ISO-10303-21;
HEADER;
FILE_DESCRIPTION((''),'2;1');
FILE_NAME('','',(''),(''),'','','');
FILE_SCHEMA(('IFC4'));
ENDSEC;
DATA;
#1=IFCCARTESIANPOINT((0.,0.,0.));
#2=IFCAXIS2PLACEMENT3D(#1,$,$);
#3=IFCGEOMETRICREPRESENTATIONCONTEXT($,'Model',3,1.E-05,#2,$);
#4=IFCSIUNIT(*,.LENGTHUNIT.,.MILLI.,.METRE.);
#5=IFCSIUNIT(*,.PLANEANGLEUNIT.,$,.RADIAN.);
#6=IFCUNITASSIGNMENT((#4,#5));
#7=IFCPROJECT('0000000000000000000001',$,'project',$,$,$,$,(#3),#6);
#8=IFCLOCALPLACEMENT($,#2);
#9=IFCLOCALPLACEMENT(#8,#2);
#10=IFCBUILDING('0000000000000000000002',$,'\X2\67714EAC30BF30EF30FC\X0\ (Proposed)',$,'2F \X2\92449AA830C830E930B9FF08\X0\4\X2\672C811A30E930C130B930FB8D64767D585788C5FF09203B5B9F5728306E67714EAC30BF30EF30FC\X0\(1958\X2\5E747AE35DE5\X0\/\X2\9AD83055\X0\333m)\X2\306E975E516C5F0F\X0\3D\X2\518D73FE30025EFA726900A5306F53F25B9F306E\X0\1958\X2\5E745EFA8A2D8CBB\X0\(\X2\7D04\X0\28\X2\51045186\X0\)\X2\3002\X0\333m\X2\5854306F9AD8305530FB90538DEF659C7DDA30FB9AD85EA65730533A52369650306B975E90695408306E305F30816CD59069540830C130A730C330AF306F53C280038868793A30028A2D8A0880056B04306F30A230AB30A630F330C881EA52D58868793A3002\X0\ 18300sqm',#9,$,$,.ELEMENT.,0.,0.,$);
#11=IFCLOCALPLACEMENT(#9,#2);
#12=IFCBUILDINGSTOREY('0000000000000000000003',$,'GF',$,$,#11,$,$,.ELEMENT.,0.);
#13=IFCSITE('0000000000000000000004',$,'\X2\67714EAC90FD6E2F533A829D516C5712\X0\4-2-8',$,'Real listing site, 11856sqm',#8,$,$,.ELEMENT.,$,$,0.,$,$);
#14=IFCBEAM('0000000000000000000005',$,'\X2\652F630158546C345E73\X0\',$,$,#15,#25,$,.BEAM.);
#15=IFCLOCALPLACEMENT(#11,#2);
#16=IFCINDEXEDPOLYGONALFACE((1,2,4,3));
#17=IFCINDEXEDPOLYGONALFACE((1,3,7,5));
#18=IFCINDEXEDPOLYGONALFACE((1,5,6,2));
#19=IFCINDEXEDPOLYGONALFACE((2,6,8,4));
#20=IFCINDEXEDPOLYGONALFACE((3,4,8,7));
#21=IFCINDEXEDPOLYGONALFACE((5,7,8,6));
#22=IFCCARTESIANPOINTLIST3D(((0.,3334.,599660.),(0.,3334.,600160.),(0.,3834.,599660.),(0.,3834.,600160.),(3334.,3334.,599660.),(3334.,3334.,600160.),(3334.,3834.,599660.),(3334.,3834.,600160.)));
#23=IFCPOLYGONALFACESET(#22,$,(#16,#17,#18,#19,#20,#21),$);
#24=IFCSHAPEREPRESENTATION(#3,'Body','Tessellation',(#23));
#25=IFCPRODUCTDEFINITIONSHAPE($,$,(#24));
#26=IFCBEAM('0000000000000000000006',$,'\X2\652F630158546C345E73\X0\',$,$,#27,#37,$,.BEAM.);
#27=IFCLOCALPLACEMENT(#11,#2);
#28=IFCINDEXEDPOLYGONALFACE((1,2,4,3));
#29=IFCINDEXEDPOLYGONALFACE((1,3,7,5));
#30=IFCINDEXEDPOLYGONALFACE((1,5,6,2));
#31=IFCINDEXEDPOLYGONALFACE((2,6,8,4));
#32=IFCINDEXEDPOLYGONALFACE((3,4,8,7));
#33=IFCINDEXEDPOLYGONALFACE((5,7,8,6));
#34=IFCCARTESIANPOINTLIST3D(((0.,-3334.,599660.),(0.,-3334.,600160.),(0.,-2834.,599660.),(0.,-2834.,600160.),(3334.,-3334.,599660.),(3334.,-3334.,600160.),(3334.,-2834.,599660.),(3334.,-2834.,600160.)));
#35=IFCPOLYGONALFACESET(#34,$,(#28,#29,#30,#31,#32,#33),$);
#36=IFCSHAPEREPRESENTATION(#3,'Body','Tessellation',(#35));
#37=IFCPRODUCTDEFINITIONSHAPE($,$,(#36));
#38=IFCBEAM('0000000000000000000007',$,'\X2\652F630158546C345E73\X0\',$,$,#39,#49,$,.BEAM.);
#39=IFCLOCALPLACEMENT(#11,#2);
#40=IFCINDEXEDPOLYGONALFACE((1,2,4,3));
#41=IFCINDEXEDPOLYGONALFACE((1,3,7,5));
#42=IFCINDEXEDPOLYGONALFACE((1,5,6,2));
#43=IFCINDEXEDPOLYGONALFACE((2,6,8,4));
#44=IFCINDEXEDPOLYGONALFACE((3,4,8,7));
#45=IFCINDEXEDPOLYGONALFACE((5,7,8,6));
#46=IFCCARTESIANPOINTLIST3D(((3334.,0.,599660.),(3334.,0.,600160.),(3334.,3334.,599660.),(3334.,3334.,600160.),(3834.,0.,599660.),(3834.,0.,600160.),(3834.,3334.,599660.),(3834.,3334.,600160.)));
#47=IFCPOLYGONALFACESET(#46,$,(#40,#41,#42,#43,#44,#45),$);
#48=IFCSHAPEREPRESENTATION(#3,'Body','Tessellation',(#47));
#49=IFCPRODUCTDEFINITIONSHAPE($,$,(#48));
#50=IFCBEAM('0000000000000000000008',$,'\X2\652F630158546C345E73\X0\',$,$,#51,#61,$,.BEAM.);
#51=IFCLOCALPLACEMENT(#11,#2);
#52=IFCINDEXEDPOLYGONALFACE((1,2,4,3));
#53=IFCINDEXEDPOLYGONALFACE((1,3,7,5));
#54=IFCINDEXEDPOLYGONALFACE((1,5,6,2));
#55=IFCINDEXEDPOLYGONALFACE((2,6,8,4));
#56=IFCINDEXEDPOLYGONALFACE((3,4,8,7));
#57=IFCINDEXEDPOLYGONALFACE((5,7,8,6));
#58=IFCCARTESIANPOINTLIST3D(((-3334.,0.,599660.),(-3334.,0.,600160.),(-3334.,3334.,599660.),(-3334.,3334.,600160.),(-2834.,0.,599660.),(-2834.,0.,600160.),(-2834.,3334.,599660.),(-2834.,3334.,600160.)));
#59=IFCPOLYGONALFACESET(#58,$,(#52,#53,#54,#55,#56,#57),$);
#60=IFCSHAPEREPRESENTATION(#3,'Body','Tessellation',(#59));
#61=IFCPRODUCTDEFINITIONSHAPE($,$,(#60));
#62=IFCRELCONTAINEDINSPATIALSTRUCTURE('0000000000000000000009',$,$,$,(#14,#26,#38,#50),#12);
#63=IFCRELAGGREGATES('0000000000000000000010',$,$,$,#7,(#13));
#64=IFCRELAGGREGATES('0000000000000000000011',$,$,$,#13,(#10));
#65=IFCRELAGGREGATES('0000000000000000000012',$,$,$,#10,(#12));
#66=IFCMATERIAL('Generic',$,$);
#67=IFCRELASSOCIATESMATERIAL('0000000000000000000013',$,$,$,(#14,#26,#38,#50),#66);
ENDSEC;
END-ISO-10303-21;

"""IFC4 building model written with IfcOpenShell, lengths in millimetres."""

from ifc_helpers import new_model, si_unit, frame, frame_2d, origin, place, context, project, spatial, rectangle, extrude, material, element, save


model = new_model("IFC4")

# Units and contexts
model_context = context("Model", 3, precision=1e-05, world=origin())
ifc_project = project(units=[si_unit("LENGTHUNIT", "METRE", prefix="MILLI"), si_unit("PLANEANGLEUNIT", "RADIAN")], contexts=[model_context])

# Site, building, storey
site_placement = place(None, origin())
site = spatial("IfcSite", under=ifc_project, at=site_placement, Name="東京都港区芝公園4-2-8", ObjectType="Real listing site, 11856sqm", CompositionType="ELEMENT", RefElevation=0.0)
building_placement = place(site_placement, origin())
building = spatial("IfcBuilding", under=site, at=building_placement, Name="東京タワー (Proposed)", ObjectType="2F 鉄骨トラス（4本脚ラチス・赤白塗装）※実在の東京タワー(1958年竣工/高さ333m)の非公式3D再現。建物¥は史実の1958年建設費(約28億円)。333m塔は高さ・道路斜線・高度地区制限に非適合のため法適合チェックは参考表示。設計者欄はアカウント自動表示。 18300sqm", CompositionType="ELEMENT", ElevationOfRefHeight=0.0, ElevationOfTerrain=0.0)
storey_placement = place(building_placement, origin())
storey = spatial("IfcBuildingStorey", under=building, at=storey_placement, Name="GF", CompositionType="ELEMENT", Elevation=0.0)

# Shared definitions
ifc_material = material(Name="Generic")

# Beams
beam_1_placement = place(storey_placement, frame((0.0, 1667.0, 299830.0)))
element("IfcBeam", 1, at=beam_1_placement, inside=storey, material=ifc_material, Name="支持塔水平", PredefinedType="BEAM", context=model_context, shape_type="SweptSolid", body=[
    extrude(rectangle(XDim=3334.0, YDim=500.0, at=frame_2d((1667.0, 250.0))), frame((0.0, 1667.0, 299830.0)), (0.0, 0.0, 1.0), 500.0),
])
beam_2_placement = place(storey_placement, frame((0.0, -1667.0, 299830.0)))
element("IfcBeam", 2, at=beam_2_placement, inside=storey, material=ifc_material, Name="支持塔水平", PredefinedType="BEAM", context=model_context, shape_type="SweptSolid", body=[
    extrude(rectangle(XDim=3334.0, YDim=500.0, at=frame_2d((1667.0, 250.0))), frame((0.0, -1667.0, 299830.0)), (0.0, 0.0, 1.0), 500.0),
])
beam_3_placement = place(storey_placement, frame((1667.0, 0.0, 299830.0)))
element("IfcBeam", 3, at=beam_3_placement, inside=storey, material=ifc_material, Name="支持塔水平", PredefinedType="BEAM", context=model_context, shape_type="SweptSolid", body=[
    extrude(rectangle(XDim=500.0, YDim=3334.0, at=frame_2d((250.0, 1667.0))), frame((1667.0, 0.0, 299830.0)), (0.0, 0.0, 1.0), 500.0),
])
beam_4_placement = place(storey_placement, frame((-1667.0, 0.0, 299830.0)))
element("IfcBeam", 4, at=beam_4_placement, inside=storey, material=ifc_material, Name="支持塔水平", PredefinedType="BEAM", context=model_context, shape_type="SweptSolid", body=[
    extrude(rectangle(XDim=500.0, YDim=3334.0, at=frame_2d((250.0, 1667.0))), frame((-1667.0, 0.0, 299830.0)), (0.0, 0.0, 1.0), 500.0),
])

save(model, "model.ifc")
